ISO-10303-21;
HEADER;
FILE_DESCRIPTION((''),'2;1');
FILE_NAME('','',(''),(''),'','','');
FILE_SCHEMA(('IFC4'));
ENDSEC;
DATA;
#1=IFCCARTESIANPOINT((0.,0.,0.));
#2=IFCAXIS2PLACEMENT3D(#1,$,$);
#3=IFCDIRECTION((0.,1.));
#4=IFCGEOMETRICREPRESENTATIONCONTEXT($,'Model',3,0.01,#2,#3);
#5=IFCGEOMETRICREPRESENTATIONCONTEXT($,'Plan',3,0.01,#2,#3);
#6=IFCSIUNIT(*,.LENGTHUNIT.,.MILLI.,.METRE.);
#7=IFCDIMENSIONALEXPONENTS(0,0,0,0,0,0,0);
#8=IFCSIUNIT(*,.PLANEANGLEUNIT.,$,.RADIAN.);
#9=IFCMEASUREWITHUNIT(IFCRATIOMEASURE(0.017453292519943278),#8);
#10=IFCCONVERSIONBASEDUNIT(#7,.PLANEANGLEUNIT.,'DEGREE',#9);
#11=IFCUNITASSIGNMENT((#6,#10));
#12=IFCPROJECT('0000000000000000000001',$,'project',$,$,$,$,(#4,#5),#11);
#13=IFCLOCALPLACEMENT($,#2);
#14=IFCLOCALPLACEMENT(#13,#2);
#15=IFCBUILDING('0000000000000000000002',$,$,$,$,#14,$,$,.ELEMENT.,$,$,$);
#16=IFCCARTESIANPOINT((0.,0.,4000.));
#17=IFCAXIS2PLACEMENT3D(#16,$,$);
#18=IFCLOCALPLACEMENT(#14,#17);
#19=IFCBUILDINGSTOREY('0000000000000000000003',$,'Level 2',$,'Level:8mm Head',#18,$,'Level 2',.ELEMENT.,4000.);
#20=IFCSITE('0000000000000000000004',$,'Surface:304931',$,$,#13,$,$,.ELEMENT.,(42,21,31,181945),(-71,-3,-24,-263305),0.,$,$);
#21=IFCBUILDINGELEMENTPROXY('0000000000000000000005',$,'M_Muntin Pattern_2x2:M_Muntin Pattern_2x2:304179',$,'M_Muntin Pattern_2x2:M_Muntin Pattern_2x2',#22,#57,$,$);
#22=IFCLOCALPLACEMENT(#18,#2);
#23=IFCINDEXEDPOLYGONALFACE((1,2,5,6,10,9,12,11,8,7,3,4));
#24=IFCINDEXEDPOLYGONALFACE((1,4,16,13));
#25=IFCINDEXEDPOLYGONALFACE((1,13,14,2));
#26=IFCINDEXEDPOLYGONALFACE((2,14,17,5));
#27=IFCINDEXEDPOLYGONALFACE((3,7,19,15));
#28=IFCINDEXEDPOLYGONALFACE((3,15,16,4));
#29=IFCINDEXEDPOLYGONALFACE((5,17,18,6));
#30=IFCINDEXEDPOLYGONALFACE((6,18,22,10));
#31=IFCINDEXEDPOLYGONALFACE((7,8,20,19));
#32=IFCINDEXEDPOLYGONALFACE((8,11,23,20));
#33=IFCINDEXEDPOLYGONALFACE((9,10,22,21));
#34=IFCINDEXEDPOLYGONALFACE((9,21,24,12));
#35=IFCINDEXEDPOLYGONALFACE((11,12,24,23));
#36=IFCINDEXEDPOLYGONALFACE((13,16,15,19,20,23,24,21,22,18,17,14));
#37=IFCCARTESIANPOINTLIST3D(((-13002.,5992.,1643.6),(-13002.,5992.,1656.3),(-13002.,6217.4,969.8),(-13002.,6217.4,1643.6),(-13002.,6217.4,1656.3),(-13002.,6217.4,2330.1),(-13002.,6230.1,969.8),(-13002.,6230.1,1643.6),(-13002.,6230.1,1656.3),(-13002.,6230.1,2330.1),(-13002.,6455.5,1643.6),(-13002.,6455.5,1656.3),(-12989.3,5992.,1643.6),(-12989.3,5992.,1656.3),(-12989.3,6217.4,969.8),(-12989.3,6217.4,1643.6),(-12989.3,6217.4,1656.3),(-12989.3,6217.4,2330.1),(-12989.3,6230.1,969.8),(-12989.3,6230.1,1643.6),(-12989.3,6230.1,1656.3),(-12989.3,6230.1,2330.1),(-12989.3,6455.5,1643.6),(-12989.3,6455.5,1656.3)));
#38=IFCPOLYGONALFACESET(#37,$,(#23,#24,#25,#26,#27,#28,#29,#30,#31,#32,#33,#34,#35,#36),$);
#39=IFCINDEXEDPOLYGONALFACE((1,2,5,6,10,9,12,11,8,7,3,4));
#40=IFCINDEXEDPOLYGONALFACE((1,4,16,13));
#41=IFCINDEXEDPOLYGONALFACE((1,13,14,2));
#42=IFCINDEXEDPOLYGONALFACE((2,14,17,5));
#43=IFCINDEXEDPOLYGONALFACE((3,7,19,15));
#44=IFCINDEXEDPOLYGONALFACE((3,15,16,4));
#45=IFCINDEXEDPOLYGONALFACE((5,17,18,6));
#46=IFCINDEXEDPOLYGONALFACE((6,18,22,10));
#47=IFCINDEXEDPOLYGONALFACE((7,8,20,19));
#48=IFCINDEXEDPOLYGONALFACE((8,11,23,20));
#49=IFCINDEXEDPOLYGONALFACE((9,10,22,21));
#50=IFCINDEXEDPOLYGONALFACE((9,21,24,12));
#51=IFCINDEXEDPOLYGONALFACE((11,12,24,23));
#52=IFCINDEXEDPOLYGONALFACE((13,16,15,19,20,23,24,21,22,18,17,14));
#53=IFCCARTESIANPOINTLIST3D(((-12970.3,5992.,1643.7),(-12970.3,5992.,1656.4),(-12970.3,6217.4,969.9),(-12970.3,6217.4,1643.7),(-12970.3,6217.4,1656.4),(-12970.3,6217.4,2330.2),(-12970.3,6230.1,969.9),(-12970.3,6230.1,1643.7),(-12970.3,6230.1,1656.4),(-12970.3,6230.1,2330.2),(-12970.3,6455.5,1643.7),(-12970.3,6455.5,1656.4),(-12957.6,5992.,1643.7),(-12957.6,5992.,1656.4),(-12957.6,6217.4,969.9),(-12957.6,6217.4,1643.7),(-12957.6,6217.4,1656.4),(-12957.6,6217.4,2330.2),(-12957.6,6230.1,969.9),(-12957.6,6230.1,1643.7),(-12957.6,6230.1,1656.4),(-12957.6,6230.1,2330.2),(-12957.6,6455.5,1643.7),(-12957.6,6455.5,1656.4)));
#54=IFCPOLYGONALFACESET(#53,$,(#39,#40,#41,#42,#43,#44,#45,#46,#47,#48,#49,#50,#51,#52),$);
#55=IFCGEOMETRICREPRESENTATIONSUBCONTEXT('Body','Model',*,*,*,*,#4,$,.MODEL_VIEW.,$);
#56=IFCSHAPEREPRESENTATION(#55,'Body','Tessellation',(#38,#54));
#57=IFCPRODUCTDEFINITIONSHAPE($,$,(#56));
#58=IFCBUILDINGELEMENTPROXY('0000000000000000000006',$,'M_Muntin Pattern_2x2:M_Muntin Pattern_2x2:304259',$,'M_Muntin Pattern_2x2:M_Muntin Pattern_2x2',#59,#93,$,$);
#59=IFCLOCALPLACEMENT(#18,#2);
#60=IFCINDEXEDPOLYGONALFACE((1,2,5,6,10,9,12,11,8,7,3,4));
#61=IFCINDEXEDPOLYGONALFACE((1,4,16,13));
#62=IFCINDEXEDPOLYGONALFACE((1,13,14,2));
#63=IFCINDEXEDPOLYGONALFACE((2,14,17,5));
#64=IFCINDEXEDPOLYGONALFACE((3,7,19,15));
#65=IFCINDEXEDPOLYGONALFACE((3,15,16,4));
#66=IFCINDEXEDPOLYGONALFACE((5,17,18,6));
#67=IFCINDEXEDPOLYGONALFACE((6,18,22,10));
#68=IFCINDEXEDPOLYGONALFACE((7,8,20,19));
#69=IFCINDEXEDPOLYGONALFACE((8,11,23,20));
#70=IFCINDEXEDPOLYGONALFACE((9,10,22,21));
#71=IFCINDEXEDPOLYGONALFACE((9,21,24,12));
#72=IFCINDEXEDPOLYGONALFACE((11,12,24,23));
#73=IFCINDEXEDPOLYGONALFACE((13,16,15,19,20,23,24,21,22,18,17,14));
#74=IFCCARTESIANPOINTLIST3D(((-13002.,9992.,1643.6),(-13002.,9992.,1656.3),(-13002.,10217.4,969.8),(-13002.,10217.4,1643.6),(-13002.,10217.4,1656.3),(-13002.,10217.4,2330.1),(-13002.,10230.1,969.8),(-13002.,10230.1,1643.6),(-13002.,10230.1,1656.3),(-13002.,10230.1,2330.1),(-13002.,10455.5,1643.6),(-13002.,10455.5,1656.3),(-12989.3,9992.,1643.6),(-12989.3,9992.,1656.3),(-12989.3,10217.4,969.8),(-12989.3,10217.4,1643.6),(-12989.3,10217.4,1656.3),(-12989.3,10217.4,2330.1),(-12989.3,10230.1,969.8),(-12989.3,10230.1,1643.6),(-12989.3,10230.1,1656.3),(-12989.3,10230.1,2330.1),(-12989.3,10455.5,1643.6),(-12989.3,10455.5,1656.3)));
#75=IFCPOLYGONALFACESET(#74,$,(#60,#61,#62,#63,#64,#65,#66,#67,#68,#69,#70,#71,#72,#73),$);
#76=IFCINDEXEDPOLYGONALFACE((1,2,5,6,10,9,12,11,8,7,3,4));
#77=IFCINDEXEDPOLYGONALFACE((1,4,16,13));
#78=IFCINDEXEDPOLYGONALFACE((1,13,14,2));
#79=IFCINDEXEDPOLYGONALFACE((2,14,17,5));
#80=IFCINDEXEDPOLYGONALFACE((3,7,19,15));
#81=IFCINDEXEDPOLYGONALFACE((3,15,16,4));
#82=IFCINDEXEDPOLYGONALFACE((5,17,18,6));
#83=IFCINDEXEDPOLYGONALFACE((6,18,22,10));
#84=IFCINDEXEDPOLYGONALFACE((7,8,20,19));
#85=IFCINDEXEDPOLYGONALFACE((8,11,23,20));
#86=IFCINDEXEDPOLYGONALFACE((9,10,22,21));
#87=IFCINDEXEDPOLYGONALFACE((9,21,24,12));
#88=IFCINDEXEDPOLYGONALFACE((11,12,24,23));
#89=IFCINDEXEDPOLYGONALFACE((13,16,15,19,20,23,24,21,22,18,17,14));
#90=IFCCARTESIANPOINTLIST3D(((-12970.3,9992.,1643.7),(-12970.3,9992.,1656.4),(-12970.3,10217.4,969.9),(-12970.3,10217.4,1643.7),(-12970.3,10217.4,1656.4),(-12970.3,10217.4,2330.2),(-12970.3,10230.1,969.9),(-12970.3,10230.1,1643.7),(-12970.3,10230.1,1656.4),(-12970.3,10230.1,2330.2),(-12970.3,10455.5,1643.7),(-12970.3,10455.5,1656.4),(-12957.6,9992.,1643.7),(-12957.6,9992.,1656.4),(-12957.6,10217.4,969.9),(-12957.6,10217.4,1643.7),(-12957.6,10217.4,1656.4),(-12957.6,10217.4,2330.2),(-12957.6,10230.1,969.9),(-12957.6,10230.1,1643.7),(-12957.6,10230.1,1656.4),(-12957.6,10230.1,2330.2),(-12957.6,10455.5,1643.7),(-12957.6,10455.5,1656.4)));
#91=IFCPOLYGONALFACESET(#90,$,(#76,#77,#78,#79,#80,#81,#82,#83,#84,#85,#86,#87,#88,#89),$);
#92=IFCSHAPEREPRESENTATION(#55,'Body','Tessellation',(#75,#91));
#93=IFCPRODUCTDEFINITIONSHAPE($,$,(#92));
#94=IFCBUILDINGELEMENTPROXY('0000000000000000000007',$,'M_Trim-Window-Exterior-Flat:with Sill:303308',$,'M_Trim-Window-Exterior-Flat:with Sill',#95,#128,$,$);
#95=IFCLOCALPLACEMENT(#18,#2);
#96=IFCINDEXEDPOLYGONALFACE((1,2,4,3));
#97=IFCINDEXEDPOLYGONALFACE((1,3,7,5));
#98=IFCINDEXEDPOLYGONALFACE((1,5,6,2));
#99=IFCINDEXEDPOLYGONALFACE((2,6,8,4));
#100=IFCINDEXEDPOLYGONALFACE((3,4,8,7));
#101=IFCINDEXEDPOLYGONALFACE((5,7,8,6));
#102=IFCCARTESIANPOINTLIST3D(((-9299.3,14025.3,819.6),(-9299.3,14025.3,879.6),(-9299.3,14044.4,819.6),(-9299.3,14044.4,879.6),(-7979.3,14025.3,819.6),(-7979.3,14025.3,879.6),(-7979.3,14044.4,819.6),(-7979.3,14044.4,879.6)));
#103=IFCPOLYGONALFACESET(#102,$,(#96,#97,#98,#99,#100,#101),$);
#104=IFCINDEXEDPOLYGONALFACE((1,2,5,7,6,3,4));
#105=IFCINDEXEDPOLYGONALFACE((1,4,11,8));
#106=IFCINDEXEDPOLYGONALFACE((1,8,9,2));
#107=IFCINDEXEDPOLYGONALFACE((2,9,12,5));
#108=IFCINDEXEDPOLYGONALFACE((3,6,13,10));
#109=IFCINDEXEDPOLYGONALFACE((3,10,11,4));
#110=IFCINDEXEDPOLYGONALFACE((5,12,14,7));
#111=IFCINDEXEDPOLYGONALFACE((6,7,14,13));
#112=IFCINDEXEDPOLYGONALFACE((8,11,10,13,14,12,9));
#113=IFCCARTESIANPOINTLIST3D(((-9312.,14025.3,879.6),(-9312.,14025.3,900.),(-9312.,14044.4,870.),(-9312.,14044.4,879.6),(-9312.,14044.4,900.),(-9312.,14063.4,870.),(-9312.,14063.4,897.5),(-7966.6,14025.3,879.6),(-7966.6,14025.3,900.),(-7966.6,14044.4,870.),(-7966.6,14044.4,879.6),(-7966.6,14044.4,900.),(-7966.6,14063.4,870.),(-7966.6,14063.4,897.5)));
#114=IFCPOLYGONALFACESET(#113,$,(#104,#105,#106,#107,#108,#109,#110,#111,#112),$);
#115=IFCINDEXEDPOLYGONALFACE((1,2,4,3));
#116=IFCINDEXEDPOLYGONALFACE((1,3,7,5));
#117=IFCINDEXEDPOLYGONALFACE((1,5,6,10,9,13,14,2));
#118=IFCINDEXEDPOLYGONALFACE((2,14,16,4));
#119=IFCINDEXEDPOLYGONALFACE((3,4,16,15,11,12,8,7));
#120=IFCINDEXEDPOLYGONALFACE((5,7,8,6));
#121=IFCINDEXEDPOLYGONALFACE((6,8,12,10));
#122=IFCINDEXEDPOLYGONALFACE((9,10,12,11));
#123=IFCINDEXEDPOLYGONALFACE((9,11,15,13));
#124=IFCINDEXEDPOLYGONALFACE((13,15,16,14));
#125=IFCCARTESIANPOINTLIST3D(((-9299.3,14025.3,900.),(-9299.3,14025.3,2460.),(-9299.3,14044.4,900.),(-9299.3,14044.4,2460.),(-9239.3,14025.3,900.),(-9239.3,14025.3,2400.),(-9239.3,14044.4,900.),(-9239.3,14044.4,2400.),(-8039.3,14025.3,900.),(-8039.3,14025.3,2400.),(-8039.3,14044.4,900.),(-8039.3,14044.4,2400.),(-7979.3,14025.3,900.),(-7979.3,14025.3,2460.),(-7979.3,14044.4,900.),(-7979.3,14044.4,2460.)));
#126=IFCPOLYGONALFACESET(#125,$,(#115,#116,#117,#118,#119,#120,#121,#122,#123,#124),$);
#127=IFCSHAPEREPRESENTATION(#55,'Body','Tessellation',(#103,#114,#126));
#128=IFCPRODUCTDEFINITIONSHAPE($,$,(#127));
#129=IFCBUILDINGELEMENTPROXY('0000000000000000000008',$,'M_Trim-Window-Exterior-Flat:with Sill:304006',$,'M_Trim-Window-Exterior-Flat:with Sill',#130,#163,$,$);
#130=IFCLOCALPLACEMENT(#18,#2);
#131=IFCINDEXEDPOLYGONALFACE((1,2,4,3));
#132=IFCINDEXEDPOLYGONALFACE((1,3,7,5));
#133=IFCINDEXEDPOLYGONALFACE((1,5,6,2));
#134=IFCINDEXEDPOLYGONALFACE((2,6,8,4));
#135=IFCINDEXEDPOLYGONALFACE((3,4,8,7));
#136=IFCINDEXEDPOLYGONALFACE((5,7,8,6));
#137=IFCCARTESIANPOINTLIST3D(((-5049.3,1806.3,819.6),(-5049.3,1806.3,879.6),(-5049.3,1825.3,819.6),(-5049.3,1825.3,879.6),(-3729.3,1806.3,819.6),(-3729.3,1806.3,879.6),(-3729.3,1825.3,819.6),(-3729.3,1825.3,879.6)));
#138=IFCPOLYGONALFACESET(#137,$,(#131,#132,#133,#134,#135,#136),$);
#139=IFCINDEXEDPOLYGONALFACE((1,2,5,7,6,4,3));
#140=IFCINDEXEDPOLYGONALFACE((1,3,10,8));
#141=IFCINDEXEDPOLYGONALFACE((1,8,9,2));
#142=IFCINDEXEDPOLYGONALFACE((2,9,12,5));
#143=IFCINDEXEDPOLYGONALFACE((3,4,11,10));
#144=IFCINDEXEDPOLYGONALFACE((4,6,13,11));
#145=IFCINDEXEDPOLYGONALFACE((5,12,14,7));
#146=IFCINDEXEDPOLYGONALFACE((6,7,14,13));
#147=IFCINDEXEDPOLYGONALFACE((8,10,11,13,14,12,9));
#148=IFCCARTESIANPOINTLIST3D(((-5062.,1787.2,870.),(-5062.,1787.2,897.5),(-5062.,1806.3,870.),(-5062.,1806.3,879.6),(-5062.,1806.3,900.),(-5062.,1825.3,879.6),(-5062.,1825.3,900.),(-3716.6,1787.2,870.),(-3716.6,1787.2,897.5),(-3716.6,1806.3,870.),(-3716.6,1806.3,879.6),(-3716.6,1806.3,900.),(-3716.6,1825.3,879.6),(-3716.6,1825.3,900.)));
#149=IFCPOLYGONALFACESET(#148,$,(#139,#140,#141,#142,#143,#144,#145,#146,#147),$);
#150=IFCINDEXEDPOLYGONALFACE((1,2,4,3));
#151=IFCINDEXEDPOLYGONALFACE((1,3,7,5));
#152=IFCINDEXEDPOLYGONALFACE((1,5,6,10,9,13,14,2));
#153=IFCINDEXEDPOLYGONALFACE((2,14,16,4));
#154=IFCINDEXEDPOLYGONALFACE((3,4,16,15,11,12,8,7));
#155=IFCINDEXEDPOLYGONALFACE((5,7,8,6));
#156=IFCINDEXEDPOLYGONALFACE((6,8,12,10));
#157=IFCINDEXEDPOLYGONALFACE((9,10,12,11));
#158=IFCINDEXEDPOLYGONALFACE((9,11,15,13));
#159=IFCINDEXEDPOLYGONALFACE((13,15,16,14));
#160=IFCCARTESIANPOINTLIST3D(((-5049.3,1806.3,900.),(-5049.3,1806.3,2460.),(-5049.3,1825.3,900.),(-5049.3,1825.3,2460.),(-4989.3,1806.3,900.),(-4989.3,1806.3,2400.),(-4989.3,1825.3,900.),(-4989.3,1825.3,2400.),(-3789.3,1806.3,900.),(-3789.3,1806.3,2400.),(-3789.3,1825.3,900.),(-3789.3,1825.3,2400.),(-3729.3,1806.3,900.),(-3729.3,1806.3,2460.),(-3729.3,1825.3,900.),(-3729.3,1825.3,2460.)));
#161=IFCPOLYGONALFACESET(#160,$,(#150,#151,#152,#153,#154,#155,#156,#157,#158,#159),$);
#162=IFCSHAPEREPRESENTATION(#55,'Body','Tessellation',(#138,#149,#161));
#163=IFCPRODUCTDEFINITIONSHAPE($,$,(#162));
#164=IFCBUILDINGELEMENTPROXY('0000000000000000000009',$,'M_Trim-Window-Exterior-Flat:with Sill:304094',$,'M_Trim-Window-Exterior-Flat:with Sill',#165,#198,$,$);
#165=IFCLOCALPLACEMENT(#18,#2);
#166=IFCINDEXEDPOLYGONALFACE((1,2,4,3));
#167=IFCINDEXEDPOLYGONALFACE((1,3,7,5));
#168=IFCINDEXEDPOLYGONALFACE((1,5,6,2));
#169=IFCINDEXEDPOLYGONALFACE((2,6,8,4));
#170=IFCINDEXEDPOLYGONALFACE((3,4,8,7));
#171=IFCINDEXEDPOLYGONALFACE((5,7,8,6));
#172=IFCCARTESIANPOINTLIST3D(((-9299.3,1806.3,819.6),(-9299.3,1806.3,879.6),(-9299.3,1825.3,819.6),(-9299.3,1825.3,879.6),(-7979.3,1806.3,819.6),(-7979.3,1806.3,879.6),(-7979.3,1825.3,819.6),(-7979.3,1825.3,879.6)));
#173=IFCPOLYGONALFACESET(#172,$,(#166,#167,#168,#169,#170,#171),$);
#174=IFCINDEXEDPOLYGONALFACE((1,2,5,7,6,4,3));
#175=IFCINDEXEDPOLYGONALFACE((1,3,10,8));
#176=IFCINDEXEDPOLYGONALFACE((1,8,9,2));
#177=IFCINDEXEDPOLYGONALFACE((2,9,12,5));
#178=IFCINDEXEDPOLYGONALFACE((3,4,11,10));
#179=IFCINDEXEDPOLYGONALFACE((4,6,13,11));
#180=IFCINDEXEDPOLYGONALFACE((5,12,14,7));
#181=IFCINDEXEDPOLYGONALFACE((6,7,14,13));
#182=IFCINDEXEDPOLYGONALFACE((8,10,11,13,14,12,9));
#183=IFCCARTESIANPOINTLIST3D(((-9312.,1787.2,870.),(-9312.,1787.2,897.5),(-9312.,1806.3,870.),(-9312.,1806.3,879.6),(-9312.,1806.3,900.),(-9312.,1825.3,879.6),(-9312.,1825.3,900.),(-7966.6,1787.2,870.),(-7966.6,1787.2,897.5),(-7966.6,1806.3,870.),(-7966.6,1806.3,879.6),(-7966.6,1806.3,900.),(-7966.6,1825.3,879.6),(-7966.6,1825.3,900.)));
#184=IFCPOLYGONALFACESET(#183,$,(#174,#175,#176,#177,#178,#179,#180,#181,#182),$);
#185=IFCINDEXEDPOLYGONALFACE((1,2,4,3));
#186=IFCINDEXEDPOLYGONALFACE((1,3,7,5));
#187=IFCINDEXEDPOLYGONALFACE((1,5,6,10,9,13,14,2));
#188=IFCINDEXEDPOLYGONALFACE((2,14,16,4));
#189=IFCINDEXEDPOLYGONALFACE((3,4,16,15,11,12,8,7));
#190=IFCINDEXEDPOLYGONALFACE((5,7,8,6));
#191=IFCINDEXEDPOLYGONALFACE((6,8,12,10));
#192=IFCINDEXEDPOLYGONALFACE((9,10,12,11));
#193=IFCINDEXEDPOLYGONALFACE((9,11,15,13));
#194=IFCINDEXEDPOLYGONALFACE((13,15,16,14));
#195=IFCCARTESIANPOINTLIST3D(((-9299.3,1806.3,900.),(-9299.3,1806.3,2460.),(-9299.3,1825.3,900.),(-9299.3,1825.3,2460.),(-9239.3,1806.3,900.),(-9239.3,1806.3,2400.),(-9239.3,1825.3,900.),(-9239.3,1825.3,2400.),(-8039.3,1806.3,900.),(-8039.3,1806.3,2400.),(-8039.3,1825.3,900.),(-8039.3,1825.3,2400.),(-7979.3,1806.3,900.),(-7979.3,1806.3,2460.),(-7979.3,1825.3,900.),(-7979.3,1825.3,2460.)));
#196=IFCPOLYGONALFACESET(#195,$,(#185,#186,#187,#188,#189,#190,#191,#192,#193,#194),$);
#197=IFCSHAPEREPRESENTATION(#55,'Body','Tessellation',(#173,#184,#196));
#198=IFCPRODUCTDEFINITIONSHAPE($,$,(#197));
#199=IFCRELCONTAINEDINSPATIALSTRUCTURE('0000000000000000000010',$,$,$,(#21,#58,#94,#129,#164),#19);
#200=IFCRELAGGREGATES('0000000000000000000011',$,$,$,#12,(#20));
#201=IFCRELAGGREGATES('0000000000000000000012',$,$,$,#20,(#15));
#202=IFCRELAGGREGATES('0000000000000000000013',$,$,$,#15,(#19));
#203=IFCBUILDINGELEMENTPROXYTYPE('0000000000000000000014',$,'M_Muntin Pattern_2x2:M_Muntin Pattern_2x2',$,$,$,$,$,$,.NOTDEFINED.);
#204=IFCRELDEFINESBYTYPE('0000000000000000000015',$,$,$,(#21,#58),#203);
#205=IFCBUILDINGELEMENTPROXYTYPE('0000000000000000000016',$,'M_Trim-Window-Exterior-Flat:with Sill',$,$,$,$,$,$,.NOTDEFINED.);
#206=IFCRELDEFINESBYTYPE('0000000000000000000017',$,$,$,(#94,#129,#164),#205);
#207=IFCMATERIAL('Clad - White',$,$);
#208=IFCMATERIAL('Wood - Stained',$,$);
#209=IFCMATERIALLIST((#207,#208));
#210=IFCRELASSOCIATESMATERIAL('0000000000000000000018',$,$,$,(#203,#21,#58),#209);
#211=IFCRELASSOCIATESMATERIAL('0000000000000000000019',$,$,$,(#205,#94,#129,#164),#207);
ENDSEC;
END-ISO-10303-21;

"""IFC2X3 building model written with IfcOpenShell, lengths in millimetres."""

from ifc_helpers import new_model, entity, si_unit, converted_unit, direction, frame, frame_2d, origin, place, context, subcontext, project, spatial, polyline, rectangle, outline, extrude, source, transform, mapped, material, material_list, type_object, type_shapes, element, save


model = new_model("IFC2X3")

# Units and contexts
model_context = context("Model", 3, precision=0.01, world=origin(), true_north=direction((0.0, 1.0)))
plan_context = context("Plan", 3, precision=0.01, world=origin(), true_north=direction((0.0, 1.0)))
body_context = subcontext(model_context, "Body", "Model", "MODEL_VIEW")
ifc_project = project(units=[si_unit("LENGTHUNIT", "METRE", prefix="MILLI"), converted_unit("PLANEANGLEUNIT", "DEGREE", entity("IfcRatioMeasure", 0.017453292519943278), si_unit("PLANEANGLEUNIT", "RADIAN"), dimensions=[0, 0, 0, 0, 0, 0, 0])], contexts=[model_context, plan_context])

# Site, building, storey
site_placement = place(None, origin())
site = spatial("IfcSite", under=ifc_project, at=site_placement, Name="Surface:304931", CompositionType="ELEMENT", RefLatitude=(42, 21, 31, 181945), RefLongitude=(-71, -3, -24, -263305), RefElevation=0.0)
building_placement = place(site_placement, origin())
building = spatial("IfcBuilding", under=site, at=building_placement, CompositionType="ELEMENT")
storey_placement = place(building_placement, frame((0.0, 0.0, 4000.0)))
storey = spatial("IfcBuildingStorey", under=building, at=storey_placement, Name="Level 2", ObjectType="Level:8mm Head", LongName="Level 2", CompositionType="ELEMENT", Elevation=4000.0)

# Building element proxies
ifc_material_1 = material(Name="Clad - White")
ifc_material_2 = material(Name="Wood - Stained")
ifc_material_list = material_list([ifc_material_1, ifc_material_2])
building_element_proxy_type_1 = type_object("IfcBuildingElementProxyType", Name="M_Muntin Pattern_2x2:M_Muntin Pattern_2x2", PredefinedType="NOTDEFINED", material=ifc_material_list)
shared_shape_1 = source(origin(), body_context, "Body", "SweptSolid", [
    extrude(outline(polyline([(6.4, -6.4), (680.1, -6.4), (680.1, 6.3), (6.4, 6.3), (6.4, 231.7), (-6.3, 231.7), (-6.3, 6.3), (-680.2, 6.3), (-680.2, -6.4), (-6.3, -6.4), (-6.3, -231.7), (6.4, -231.7), (6.4, -6.4)])), frame((0.0, -22.2, 680.1), z_axis=(0.0, 1.0, 0.0), x_axis=(0.0, 0.0, 1.0)), (0.0, 0.0, 1.0), 12.7),
    extrude(outline(polyline([(6.4, -6.4), (680.2, -6.4), (680.2, 6.3), (6.4, 6.3), (6.4, 231.7), (-6.3, 231.7), (-6.3, 6.3), (-680.2, 6.3), (-680.2, -6.4), (-6.3, -6.4), (-6.3, -231.7), (6.4, -231.7), (6.4, -6.4)])), frame((0.0, 9.5, 680.2), z_axis=(0.0, 1.0, 0.0), x_axis=(0.0, 0.0, 1.0)), (0.0, 0.0, 1.0), 12.7),
])
type_shapes(building_element_proxy_type_1, [shared_shape_1])
for number, where, z_axis, x_axis, name in (
    (1, (-12979.8, 6223.7, 969.9), (0.0, 0.0, 1.0), (0.0, -1.0, 0.0), "M_Muntin Pattern_2x2:M_Muntin Pattern_2x2:304179"),
    (2, (-12979.8, 10223.7, 969.9), (0.0, 0.0, 1.0), (0.0, -1.0, 0.0), "M_Muntin Pattern_2x2:M_Muntin Pattern_2x2:304259"),
):
    element("IfcBuildingElementProxy", number, at=place(storey_placement, frame(where, z_axis=z_axis, x_axis=x_axis)), inside=storey, type_object=building_element_proxy_type_1, material=ifc_material_list, Name=name, ObjectType="M_Muntin Pattern_2x2:M_Muntin Pattern_2x2", context=body_context, shape_type="MappedRepresentation", body=[
        mapped(shared_shape_1, transform((0.0, 0.0, 0.0), scale=1.0)),
    ])
building_element_proxy_type_2 = type_object("IfcBuildingElementProxyType", Name="M_Trim-Window-Exterior-Flat:with Sill", PredefinedType="NOTDEFINED", material=ifc_material_1)
shared_shape_2 = source(origin(), body_context, "Body", "SweptSolid", [
    extrude(rectangle(XDim=1320.0, YDim=60.0, at=frame_2d((0.0, 0.0), x_axis=(1.0, 0.0))), frame((0.0, -1550.4, 0.0), z_axis=(0.0, 0.0, 1.0), x_axis=(-1.0, 0.0, 0.0)), (0.0, 0.0, 1.0), 19.0),
    extrude(outline(polyline([(-19.0, -15.2), (0.0, -15.2), (0.0, -5.7), (19.0, -5.7), (19.0, 14.8), (0.0, 14.8), (-19.0, 12.3), (-19.0, -15.2)])), frame((-672.7, -1514.8, 19.0), z_axis=(1.0, 0.0, 0.0), x_axis=(0.0, 0.0, -1.0)), (0.0, 0.0, 1.0), 1345.4),
    extrude(outline(polyline([(-795.0, -660.0), (765.0, -660.0), (765.0, -600.0), (-735.0, -600.0), (-735.0, 600.0), (765.0, 600.0), (765.0, 660.0), (-795.0, 660.0), (-795.0, -660.0)])), frame((0.0, -735.0, 0.0), z_axis=(0.0, 0.0, 1.0), x_axis=(0.0, -1.0, 0.0)), (0.0, 0.0, 1.0), 19.0),
])
type_shapes(building_element_proxy_type_2, [shared_shape_2])
for number, where, z_axis, x_axis, name in (
    (3, (-8639.3, 14025.3, 2400.0), (0.0, 1.0, 0.0), (-1.0, 0.0, 0.0), "M_Trim-Window-Exterior-Flat:with Sill:303308"),
    (4, (-4389.3, 1825.3, 2400.0), (0.0, -1.0, 0.0), (1.0, 0.0, 0.0), "M_Trim-Window-Exterior-Flat:with Sill:304006"),
    (5, (-8639.3, 1825.3, 2400.0), (0.0, -1.0, 0.0), (1.0, 0.0, 0.0), "M_Trim-Window-Exterior-Flat:with Sill:304094"),
):
    element("IfcBuildingElementProxy", number, at=place(storey_placement, frame(where, z_axis=z_axis, x_axis=x_axis)), inside=storey, type_object=building_element_proxy_type_2, material=ifc_material_1, Name=name, ObjectType="M_Trim-Window-Exterior-Flat:with Sill", context=body_context, shape_type="MappedRepresentation", body=[
        mapped(shared_shape_2, transform((0.0, 0.0, 0.0), scale=1.0)),
    ])

save(model, "model.ifc")
